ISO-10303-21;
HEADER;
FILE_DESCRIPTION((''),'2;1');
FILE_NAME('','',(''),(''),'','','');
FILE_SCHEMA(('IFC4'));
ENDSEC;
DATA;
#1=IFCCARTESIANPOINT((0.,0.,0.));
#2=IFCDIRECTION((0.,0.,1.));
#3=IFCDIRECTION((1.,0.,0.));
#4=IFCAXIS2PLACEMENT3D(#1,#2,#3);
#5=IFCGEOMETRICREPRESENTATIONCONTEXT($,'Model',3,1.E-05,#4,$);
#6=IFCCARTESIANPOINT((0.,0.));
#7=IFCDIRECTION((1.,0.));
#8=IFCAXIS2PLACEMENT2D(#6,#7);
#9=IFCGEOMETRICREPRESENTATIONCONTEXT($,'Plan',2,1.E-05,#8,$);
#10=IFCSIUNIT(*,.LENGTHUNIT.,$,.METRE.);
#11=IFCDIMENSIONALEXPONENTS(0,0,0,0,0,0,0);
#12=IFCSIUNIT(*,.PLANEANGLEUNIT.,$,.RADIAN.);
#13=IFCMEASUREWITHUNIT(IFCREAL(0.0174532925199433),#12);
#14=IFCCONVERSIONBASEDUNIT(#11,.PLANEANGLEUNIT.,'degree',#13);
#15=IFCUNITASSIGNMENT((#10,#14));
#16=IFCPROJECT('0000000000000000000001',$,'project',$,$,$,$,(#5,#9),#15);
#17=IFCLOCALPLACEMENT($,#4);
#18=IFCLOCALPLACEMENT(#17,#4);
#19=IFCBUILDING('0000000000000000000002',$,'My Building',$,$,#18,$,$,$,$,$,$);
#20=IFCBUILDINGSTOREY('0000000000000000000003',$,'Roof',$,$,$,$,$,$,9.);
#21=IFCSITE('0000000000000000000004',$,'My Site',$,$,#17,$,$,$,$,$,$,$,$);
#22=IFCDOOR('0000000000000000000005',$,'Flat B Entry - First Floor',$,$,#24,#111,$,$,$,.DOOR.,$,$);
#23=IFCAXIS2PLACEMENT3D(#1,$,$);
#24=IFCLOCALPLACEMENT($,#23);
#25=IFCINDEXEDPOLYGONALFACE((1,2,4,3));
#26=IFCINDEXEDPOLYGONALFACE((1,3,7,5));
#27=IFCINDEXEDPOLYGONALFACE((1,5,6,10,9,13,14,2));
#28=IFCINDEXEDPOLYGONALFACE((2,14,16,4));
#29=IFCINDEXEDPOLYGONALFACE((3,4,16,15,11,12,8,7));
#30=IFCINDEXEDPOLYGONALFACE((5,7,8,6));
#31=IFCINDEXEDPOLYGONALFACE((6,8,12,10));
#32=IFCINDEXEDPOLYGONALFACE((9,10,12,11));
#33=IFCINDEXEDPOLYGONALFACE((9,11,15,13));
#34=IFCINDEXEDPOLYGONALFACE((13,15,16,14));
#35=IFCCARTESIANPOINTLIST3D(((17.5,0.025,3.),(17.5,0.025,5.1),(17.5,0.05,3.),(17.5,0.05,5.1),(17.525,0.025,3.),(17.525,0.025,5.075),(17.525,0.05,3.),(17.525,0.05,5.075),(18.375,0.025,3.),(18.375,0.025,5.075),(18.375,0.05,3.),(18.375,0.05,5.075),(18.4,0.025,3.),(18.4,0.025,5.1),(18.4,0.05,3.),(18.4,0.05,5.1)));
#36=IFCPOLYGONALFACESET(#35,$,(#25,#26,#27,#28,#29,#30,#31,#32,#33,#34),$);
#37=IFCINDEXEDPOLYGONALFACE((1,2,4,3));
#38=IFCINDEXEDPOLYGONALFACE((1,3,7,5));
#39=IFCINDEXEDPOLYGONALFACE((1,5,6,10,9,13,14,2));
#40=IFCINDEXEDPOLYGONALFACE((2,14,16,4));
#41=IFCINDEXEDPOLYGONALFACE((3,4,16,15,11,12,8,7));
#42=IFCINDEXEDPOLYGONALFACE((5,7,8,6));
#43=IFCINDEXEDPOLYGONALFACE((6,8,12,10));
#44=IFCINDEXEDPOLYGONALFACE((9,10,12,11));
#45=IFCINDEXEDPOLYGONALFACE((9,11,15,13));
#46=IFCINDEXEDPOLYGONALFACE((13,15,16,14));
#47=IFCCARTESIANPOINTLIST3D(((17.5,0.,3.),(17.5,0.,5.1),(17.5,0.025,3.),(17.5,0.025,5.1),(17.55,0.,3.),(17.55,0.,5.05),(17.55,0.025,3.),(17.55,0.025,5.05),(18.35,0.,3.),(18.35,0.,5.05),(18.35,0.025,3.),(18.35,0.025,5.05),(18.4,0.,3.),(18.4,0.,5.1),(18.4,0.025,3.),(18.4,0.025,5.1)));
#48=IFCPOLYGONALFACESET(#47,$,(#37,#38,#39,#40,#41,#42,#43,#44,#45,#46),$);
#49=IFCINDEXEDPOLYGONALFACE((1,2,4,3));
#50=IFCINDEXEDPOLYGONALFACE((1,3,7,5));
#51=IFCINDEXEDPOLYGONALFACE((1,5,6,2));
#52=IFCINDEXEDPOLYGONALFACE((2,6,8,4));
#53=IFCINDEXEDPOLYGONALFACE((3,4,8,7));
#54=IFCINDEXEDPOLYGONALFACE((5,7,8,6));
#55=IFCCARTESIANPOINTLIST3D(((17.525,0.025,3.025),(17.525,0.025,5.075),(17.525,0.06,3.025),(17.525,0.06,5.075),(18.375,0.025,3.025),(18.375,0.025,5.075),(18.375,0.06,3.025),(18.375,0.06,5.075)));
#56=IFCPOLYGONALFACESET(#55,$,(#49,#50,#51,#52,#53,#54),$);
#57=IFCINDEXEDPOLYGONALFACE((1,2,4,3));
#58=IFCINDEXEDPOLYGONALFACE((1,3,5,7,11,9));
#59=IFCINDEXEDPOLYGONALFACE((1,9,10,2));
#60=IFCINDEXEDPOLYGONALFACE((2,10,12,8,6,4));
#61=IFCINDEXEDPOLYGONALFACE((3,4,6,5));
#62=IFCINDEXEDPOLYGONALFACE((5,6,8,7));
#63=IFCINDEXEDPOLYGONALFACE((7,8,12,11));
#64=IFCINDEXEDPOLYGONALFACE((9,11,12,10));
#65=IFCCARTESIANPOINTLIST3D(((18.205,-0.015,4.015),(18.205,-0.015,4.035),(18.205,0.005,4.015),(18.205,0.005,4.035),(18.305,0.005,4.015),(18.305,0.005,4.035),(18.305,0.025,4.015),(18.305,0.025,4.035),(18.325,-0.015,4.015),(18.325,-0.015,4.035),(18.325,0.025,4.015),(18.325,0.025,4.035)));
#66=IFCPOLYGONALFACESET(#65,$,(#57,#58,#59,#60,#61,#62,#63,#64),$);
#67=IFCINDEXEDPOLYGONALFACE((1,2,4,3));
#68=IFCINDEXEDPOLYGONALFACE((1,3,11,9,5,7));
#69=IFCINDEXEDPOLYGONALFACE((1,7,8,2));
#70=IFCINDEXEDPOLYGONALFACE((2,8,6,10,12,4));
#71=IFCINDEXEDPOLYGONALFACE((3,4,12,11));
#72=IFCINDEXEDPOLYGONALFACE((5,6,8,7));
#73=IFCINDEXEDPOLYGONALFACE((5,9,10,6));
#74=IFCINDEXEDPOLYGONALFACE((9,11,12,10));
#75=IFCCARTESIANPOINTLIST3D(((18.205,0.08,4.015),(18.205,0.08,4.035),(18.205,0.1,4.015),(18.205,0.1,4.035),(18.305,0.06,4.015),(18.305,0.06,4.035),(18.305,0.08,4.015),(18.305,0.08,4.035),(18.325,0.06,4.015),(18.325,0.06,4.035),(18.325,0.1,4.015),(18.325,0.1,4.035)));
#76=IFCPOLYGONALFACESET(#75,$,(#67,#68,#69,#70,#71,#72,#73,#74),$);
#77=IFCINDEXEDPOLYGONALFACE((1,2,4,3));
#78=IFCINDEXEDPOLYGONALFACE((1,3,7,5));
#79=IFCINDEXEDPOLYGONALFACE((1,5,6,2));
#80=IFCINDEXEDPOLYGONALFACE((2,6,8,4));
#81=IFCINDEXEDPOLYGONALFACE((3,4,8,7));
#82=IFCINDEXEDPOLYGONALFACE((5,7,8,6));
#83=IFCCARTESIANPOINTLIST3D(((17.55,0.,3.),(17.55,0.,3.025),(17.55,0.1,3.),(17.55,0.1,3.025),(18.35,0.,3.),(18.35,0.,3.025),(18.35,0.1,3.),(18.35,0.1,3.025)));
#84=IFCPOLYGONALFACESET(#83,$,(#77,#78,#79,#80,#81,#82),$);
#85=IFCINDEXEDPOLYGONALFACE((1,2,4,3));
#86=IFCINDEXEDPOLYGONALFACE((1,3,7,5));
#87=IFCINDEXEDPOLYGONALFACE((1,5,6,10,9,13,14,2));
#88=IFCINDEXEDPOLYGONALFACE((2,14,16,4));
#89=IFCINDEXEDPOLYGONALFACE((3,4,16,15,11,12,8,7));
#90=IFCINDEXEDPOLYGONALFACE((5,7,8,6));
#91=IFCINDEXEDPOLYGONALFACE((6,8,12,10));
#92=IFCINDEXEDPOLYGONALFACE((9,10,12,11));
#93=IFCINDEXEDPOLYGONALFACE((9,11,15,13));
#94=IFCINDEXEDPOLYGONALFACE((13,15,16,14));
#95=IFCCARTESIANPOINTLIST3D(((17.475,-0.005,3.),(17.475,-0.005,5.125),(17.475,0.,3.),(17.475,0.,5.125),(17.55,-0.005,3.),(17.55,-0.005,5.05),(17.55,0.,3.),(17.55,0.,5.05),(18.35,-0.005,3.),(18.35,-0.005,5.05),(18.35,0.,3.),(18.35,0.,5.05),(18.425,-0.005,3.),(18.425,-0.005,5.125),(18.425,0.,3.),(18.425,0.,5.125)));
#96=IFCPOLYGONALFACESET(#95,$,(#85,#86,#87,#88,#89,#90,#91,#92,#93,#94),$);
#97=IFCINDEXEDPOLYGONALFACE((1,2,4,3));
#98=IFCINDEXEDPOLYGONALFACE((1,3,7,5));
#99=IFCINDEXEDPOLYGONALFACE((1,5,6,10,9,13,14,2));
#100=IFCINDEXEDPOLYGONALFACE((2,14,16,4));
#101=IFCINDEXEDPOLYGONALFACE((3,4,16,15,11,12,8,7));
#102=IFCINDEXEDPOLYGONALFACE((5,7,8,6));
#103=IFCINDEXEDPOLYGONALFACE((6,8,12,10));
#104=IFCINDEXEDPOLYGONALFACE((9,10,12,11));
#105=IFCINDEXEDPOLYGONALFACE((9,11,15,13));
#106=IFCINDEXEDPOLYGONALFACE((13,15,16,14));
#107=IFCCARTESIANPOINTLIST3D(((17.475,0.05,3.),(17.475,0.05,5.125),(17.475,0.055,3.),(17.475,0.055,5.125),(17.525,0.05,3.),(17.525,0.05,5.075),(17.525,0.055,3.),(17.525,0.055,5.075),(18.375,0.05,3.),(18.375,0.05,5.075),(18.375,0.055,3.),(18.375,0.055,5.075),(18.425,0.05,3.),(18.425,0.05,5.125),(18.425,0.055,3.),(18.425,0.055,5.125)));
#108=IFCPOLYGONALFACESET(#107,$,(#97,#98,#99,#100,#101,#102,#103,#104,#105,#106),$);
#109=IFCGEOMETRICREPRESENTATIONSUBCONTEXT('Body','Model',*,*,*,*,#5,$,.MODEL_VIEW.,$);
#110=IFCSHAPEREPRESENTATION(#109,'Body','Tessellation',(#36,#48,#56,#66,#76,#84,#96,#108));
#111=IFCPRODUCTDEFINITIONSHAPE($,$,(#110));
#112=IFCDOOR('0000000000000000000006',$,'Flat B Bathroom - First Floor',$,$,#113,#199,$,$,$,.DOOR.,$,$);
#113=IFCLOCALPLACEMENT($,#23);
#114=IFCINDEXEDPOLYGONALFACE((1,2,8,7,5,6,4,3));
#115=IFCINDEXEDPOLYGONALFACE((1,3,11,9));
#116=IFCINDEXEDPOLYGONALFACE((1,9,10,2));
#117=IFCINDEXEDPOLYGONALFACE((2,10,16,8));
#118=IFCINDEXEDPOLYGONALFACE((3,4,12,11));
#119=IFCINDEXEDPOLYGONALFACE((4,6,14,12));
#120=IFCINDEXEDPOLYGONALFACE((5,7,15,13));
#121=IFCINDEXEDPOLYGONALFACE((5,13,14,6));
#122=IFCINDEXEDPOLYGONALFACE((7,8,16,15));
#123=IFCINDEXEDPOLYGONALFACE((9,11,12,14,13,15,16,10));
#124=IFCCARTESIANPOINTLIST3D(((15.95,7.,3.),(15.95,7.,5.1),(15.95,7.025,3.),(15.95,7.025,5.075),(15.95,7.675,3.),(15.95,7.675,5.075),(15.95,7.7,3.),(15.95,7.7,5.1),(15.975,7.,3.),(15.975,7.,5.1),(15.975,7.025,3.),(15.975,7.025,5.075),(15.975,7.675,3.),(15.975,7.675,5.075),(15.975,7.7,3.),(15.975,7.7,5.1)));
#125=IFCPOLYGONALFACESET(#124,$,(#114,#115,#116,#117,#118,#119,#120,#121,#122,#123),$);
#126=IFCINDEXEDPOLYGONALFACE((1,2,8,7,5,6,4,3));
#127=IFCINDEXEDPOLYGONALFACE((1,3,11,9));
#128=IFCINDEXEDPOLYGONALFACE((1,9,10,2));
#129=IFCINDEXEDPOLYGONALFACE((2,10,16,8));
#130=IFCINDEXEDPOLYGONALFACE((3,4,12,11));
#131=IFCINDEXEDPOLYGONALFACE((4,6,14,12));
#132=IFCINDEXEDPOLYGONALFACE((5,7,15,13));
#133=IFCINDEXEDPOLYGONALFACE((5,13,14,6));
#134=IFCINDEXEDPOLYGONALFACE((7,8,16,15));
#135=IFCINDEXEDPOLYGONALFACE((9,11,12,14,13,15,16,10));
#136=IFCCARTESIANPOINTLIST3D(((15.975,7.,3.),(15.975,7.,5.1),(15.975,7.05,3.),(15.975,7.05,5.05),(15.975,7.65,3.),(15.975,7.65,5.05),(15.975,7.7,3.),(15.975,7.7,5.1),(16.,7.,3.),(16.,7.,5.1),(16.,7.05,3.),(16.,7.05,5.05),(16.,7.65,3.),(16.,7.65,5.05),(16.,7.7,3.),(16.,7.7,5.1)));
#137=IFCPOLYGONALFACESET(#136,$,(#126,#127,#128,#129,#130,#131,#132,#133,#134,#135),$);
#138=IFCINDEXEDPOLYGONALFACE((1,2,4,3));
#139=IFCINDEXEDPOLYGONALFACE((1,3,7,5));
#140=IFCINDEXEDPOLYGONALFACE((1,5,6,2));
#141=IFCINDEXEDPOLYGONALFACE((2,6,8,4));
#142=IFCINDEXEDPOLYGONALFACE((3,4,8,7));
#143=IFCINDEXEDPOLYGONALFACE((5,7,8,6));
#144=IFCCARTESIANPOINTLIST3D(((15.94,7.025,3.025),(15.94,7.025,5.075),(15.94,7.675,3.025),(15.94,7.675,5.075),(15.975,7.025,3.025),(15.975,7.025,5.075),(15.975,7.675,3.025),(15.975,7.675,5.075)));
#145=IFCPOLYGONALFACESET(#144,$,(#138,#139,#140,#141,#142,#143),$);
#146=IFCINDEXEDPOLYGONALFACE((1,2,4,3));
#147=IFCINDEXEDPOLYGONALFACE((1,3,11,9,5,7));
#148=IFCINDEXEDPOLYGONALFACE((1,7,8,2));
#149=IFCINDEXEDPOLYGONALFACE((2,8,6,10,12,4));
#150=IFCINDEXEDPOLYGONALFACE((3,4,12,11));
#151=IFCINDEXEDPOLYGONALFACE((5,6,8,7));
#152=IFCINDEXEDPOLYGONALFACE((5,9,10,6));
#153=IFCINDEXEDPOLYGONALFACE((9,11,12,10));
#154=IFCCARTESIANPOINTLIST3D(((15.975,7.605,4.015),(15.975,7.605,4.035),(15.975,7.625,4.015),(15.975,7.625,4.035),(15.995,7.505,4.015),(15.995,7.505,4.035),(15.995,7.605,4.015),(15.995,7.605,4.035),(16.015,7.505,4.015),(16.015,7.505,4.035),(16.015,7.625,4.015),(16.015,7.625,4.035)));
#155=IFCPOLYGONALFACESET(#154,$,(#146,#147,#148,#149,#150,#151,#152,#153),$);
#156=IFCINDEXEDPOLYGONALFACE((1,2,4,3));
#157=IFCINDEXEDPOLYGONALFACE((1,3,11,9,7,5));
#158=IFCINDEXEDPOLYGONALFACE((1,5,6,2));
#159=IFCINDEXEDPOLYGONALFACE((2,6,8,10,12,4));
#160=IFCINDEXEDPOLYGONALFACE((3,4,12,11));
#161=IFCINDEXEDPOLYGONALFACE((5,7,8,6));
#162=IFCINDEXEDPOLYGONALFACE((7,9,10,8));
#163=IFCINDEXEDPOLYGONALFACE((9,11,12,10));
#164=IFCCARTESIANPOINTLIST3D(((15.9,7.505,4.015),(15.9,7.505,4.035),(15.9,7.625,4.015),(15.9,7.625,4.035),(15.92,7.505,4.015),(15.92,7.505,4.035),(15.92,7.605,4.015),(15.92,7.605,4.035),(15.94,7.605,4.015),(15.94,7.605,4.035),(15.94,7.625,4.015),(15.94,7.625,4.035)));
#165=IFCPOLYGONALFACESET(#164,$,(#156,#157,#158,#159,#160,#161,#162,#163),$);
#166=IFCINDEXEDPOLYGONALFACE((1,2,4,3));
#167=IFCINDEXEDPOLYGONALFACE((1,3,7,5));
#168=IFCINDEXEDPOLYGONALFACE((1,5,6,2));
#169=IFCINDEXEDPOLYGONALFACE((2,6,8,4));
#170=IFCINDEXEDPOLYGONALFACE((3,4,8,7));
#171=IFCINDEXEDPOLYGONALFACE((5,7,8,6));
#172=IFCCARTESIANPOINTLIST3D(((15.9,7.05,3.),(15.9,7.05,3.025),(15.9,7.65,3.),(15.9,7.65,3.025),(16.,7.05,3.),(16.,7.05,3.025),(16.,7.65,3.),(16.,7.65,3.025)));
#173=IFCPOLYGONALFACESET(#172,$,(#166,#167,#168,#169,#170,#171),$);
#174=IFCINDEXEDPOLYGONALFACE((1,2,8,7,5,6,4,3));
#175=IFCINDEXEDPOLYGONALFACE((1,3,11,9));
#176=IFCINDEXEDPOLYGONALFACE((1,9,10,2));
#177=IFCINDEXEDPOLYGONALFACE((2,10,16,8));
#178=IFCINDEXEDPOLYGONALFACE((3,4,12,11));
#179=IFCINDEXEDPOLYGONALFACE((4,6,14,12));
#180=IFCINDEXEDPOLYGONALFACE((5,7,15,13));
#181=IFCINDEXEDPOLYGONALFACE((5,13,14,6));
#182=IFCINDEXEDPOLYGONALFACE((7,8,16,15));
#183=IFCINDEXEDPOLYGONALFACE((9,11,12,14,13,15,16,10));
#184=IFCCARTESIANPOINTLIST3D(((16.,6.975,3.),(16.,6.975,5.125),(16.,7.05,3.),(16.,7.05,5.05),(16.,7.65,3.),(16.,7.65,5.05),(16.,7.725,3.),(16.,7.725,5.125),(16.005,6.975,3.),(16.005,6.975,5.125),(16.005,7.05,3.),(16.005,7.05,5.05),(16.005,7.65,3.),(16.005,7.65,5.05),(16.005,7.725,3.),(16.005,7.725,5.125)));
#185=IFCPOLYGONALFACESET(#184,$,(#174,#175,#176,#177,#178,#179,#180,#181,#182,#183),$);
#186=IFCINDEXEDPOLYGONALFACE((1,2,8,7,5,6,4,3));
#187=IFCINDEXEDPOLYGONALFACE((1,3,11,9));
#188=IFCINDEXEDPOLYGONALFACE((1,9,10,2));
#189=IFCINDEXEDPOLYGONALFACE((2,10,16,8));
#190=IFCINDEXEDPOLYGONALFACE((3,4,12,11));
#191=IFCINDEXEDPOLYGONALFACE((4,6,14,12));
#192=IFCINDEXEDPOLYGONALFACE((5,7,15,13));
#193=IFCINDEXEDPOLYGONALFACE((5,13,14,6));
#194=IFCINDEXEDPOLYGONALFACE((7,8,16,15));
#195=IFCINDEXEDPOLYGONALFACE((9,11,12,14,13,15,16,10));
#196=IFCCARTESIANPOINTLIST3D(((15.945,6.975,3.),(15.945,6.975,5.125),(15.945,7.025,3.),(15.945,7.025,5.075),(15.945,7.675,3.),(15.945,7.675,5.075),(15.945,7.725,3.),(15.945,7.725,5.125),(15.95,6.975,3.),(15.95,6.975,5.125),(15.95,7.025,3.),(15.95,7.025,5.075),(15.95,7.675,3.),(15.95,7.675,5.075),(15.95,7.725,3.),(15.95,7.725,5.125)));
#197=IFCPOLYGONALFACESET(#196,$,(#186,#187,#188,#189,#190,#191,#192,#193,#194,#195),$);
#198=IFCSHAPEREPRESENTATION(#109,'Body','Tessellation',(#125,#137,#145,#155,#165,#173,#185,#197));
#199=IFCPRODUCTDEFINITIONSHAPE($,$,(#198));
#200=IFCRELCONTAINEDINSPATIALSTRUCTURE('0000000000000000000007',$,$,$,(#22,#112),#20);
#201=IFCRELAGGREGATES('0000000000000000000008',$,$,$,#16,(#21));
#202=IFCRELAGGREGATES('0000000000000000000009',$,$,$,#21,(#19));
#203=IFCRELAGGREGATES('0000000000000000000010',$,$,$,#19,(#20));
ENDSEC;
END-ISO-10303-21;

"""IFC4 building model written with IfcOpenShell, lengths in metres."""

from ifc_helpers import new_model, entity, si_unit, converted_unit, frame, origin_with_axes, origin_2d_with_axis, place, context, subcontext, project, spatial, line, indexed_curve, outline, extrude, element, save


model = new_model("IFC4")

# Units and contexts
model_context = context("Model", 3, precision=1e-05, world=origin_with_axes())
plan_context = context("Plan", 2, precision=1e-05, world=origin_2d_with_axis())
body_context = subcontext(model_context, "Body", "Model", "MODEL_VIEW")
ifc_project = project(units=[si_unit("LENGTHUNIT", "METRE"), converted_unit("PLANEANGLEUNIT", "degree", entity("IfcReal", 0.0174532925199433), si_unit("PLANEANGLEUNIT", "RADIAN"), dimensions=[0, 0, 0, 0, 0, 0, 0])], contexts=[model_context, plan_context])

# Site, building, storey
site_placement = place(None, origin_with_axes())
site = spatial("IfcSite", under=ifc_project, at=site_placement, Name="My Site")
building_placement = place(site_placement, origin_with_axes())
building = spatial("IfcBuilding", under=site, at=building_placement, Name="My Building")
storey = spatial("IfcBuildingStorey", under=building, Name="Roof", Elevation=9.0)

# Doors
door_1_placement = place(None, frame((17.5, 0.0, 3.0), z_axis=(0.0, 0.0, 1.0), x_axis=(1.0, 0.0, 0.0)))
element("IfcDoor", 1, at=door_1_placement, inside=storey, Name="Flat B Entry - First Floor", PredefinedType="DOOR", context=body_context, shape_type="SweptSolid", body=[
    extrude(outline(indexed_curve([(0.0, 0.0), (0.0, 2.1), (0.9, 2.1), (0.9, 0.0), (0.875, 0.0), (0.875, 2.075), (0.025, 2.075), (0.025, 0.0)], segments=[line(1, 2, 3, 4, 5, 6, 7, 8, 1)])), frame((0.0, 0.025, 0.0), z_axis=(0.0, -1.0, 0.0), x_axis=(1.0, 0.0, 0.0)), (0.0, 0.0, -1.0), 0.025),
    extrude(outline(indexed_curve([(0.0, 0.0), (0.0, 2.1), (0.9, 2.1), (0.9, 0.0), (0.85, 0.0), (0.85, 2.05), (0.05, 2.05), (0.05, 0.0)], segments=[line(1, 2, 3, 4, 5, 6, 7, 8, 1)])), frame((0.0, 0.0, 0.0), z_axis=(0.0, -1.0, 0.0), x_axis=(1.0, 0.0, 0.0)), (0.0, 0.0, -1.0), 0.025),
    extrude(outline(indexed_curve([(0.0, 0.0), (0.85, 0.0), (0.85, 0.035), (0.0, 0.035)], segments=[line(1, 2, 3, 4, 1)])), frame((0.025, 0.025, 0.025), z_axis=(0.0, 0.0, 1.0), x_axis=(1.0, 0.0, 0.0)), (0.0, 0.0, 1.0), 2.05),
    extrude(outline(indexed_curve([(0.0, 0.0), (0.0, -0.04), (-0.12, -0.04), (-0.12, -0.02), (-0.02, -0.02), (-0.02, 0.0)], segments=[line(1, 2, 3, 4, 5, 6, 1)])), frame((0.825, 0.025, 1.015), z_axis=(0.0, 0.0, 1.0), x_axis=(1.0, 0.0, 0.0)), (0.0, 0.0, 1.0), 0.02),
    extrude(outline(indexed_curve([(0.0, 0.0), (0.0, 0.04), (-0.12, 0.04), (-0.12, 0.02), (-0.02, 0.02), (-0.02, 0.0)], segments=[line(1, 2, 3, 4, 5, 6, 1)])), frame((0.825, 0.06, 1.015), z_axis=(0.0, 0.0, 1.0), x_axis=(1.0, 0.0, 0.0)), (0.0, 0.0, 1.0), 0.02),
    extrude(outline(indexed_curve([(0.0, 0.0), (0.8, 0.0), (0.8, 0.1), (0.0, 0.1)], segments=[line(1, 2, 3, 4, 1)])), frame((0.05, 0.0, 0.0), z_axis=(0.0, 0.0, 1.0), x_axis=(1.0, 0.0, 0.0)), (0.0, 0.0, 1.0), 0.025),
    extrude(outline(indexed_curve([(0.0, 0.0), (0.0, 2.125), (0.95, 2.125), (0.95, 0.0), (0.875, 0.0), (0.875, 2.05), (0.075, 2.05), (0.075, 0.0)], segments=[line(1, 2, 3, 4, 5, 6, 7, 8, 1)])), frame((-0.025, -0.005, 0.0), z_axis=(0.0, -1.0, 0.0), x_axis=(1.0, 0.0, 0.0)), (0.0, 0.0, -1.0), 0.005),
    extrude(outline(indexed_curve([(0.0, 0.0), (0.0, 2.125), (0.95, 2.125), (0.95, 0.0), (0.9, 0.0), (0.9, 2.075), (0.05, 2.075), (0.05, 0.0)], segments=[line(1, 2, 3, 4, 5, 6, 7, 8, 1)])), frame((-0.025, 0.05, 0.0), z_axis=(0.0, -1.0, 0.0), x_axis=(1.0, 0.0, 0.0)), (0.0, 0.0, -1.0), 0.005),
])
door_2_placement = place(None, frame((16.0, 7.0, 3.0), z_axis=(0.0, 0.0, 1.0), x_axis=(0.0, 1.0, 0.0)))
element("IfcDoor", 2, at=door_2_placement, inside=storey, Name="Flat B Bathroom - First Floor", PredefinedType="DOOR", context=body_context, shape_type="SweptSolid", body=[
    extrude(outline(indexed_curve([(0.0, 0.0), (0.0, 2.1), (0.7, 2.1), (0.7, 0.0), (0.675, 0.0), (0.675, 2.075), (0.025, 2.075), (0.025, 0.0)], segments=[line(1, 2, 3, 4, 5, 6, 7, 8, 1)])), frame((0.0, 0.025, 0.0), z_axis=(0.0, -1.0, 0.0), x_axis=(1.0, 0.0, 0.0)), (0.0, 0.0, -1.0), 0.025),
    extrude(outline(indexed_curve([(0.0, 0.0), (0.0, 2.1), (0.7, 2.1), (0.7, 0.0), (0.65, 0.0), (0.65, 2.05), (0.05, 2.05), (0.05, 0.0)], segments=[line(1, 2, 3, 4, 5, 6, 7, 8, 1)])), frame((0.0, 0.0, 0.0), z_axis=(0.0, -1.0, 0.0), x_axis=(1.0, 0.0, 0.0)), (0.0, 0.0, -1.0), 0.025),
    extrude(outline(indexed_curve([(0.0, 0.0), (0.65, 0.0), (0.65, 0.035), (0.0, 0.035)], segments=[line(1, 2, 3, 4, 1)])), frame((0.025, 0.025, 0.025), z_axis=(0.0, 0.0, 1.0), x_axis=(1.0, 0.0, 0.0)), (0.0, 0.0, 1.0), 2.05),
    extrude(outline(indexed_curve([(0.0, 0.0), (0.0, -0.04), (-0.12, -0.04), (-0.12, -0.02), (-0.02, -0.02), (-0.02, 0.0)], segments=[line(1, 2, 3, 4, 5, 6, 1)])), frame((0.625, 0.025, 1.015), z_axis=(0.0, 0.0, 1.0), x_axis=(1.0, 0.0, 0.0)), (0.0, 0.0, 1.0), 0.02),
    extrude(outline(indexed_curve([(0.0, 0.0), (0.0, 0.04), (-0.12, 0.04), (-0.12, 0.02), (-0.02, 0.02), (-0.02, 0.0)], segments=[line(1, 2, 3, 4, 5, 6, 1)])), frame((0.625, 0.06, 1.015), z_axis=(0.0, 0.0, 1.0), x_axis=(1.0, 0.0, 0.0)), (0.0, 0.0, 1.0), 0.02),
    extrude(outline(indexed_curve([(0.0, 0.0), (0.6, 0.0), (0.6, 0.1), (0.0, 0.1)], segments=[line(1, 2, 3, 4, 1)])), frame((0.05, 0.0, 0.0), z_axis=(0.0, 0.0, 1.0), x_axis=(1.0, 0.0, 0.0)), (0.0, 0.0, 1.0), 0.025),
    extrude(outline(indexed_curve([(0.0, 0.0), (0.0, 2.125), (0.75, 2.125), (0.75, 0.0), (0.675, 0.0), (0.675, 2.05), (0.075, 2.05), (0.075, 0.0)], segments=[line(1, 2, 3, 4, 5, 6, 7, 8, 1)])), frame((-0.025, -0.005, 0.0), z_axis=(0.0, -1.0, 0.0), x_axis=(1.0, 0.0, 0.0)), (0.0, 0.0, -1.0), 0.005),
    extrude(outline(indexed_curve([(0.0, 0.0), (0.0, 2.125), (0.75, 2.125), (0.75, 0.0), (0.7, 0.0), (0.7, 2.075), (0.05, 2.075), (0.05, 0.0)], segments=[line(1, 2, 3, 4, 5, 6, 7, 8, 1)])), frame((-0.025, 0.05, 0.0), z_axis=(0.0, -1.0, 0.0), x_axis=(1.0, 0.0, 0.0)), (0.0, 0.0, -1.0), 0.005),
])

save(model, "model.ifc")
